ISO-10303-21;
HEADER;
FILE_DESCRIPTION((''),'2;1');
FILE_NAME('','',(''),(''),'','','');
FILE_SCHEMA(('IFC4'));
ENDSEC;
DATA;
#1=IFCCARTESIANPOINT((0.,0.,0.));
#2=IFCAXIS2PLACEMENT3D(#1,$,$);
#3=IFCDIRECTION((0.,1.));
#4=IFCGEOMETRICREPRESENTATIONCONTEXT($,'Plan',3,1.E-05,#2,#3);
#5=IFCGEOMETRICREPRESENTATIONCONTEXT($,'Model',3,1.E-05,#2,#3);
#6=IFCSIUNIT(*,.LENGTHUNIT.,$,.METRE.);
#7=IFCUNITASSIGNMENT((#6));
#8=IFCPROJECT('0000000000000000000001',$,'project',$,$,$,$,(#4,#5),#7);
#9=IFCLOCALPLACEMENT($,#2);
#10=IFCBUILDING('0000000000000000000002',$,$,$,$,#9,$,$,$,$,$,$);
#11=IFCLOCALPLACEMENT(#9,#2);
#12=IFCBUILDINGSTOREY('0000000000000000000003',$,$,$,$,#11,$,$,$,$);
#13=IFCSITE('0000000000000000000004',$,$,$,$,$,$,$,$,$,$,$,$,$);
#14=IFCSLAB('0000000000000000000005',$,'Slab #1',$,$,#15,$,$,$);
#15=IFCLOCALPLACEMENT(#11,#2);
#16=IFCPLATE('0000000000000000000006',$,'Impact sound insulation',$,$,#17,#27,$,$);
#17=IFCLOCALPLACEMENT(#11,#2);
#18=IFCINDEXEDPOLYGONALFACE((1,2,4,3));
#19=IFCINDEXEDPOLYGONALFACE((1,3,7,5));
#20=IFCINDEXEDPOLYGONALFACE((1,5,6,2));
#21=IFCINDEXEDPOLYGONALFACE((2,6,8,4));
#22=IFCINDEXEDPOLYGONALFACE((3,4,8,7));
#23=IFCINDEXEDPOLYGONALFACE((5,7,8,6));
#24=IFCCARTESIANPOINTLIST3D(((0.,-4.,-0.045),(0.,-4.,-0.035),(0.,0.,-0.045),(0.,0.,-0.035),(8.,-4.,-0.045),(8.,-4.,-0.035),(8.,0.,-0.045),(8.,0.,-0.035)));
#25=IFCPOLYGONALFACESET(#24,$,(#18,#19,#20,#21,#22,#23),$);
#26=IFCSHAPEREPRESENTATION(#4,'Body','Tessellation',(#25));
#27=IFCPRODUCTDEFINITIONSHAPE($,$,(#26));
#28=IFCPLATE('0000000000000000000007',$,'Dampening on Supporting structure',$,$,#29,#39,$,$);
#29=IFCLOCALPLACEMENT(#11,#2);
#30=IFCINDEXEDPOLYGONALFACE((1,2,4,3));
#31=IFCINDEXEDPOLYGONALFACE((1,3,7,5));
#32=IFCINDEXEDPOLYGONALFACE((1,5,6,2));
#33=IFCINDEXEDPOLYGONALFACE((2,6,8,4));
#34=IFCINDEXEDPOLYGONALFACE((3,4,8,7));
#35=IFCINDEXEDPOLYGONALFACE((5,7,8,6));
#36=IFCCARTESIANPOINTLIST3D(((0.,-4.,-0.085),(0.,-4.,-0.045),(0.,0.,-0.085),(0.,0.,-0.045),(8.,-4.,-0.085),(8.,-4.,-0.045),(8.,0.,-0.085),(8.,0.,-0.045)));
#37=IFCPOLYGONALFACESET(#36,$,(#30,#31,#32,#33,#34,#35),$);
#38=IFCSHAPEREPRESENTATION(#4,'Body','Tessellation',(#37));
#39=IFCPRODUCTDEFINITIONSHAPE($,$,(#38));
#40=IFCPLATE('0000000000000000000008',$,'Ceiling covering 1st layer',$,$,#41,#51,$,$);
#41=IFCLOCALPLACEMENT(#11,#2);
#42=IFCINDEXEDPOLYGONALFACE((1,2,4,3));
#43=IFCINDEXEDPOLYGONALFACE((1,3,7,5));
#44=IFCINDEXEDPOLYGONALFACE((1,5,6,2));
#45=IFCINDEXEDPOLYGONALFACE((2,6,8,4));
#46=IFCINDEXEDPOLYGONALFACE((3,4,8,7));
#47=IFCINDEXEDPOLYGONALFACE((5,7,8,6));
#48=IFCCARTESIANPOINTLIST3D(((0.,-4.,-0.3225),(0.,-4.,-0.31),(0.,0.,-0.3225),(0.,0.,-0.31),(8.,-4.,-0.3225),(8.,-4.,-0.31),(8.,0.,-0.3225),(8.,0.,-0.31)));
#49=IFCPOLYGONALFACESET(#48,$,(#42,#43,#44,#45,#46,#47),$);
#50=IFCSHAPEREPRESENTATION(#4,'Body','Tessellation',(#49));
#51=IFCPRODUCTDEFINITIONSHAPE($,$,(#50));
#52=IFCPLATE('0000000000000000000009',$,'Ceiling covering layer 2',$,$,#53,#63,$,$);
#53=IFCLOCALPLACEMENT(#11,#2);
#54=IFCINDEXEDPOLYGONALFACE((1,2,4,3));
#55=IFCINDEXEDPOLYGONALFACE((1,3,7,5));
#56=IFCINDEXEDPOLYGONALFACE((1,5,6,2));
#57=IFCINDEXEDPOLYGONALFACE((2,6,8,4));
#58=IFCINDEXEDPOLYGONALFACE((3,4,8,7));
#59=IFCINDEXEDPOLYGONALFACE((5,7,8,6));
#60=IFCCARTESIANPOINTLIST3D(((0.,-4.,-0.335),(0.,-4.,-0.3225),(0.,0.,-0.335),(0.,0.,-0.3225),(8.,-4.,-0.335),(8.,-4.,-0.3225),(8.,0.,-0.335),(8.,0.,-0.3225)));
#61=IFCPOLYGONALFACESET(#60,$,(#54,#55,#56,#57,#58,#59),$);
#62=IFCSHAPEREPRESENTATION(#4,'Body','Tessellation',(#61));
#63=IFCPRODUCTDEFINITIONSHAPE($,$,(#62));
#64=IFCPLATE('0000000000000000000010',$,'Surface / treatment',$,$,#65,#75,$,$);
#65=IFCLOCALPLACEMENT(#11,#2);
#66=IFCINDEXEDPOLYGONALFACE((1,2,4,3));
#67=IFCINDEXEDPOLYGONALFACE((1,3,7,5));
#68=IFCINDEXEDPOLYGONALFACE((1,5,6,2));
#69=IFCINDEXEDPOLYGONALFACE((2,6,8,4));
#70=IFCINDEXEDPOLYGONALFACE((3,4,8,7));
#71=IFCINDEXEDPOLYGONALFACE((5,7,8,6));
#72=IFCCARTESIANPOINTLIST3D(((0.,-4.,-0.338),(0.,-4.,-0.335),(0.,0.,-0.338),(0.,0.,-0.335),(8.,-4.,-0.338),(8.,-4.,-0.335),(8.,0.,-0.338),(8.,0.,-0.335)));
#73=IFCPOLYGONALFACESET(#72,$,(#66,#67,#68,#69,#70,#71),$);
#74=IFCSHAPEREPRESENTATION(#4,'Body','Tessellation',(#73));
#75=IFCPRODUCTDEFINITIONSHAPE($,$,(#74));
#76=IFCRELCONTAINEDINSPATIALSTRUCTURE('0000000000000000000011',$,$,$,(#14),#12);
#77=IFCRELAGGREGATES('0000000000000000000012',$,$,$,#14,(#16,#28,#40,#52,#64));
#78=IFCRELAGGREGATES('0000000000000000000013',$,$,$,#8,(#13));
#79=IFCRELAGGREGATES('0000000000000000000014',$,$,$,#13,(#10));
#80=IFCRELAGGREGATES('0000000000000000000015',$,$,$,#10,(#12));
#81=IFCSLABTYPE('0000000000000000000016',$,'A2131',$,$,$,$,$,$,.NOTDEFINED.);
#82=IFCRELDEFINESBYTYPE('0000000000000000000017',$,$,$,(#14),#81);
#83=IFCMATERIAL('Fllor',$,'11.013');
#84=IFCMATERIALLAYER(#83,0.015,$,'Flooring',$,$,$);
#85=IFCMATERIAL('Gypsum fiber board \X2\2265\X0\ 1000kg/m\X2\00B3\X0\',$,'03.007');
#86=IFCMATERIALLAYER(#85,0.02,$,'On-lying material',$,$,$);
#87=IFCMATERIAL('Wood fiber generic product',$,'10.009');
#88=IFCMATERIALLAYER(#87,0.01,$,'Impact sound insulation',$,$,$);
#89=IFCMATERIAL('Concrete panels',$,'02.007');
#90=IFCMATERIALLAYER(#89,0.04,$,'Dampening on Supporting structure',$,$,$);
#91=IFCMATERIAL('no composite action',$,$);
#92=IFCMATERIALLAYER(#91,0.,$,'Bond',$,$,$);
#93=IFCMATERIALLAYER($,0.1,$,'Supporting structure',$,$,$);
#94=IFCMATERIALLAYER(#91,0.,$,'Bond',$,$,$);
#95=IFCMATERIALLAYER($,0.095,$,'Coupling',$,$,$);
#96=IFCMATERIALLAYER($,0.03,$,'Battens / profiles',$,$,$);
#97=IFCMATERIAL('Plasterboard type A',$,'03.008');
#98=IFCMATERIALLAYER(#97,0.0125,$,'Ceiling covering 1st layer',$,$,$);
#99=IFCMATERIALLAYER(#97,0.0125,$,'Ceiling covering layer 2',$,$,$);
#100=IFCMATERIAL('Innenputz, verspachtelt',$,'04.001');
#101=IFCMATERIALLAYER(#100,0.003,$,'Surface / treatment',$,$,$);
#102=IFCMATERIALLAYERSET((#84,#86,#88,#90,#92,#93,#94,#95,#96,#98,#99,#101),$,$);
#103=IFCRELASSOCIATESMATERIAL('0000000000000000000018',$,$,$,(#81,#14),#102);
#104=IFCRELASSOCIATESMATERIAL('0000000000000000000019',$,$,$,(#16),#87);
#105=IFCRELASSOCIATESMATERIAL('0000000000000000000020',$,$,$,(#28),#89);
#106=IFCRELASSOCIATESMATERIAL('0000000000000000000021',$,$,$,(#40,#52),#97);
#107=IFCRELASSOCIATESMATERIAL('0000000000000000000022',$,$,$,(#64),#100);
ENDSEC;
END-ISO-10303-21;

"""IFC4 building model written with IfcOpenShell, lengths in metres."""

from ifc_helpers import new_model, si_unit, direction, frame, frame_2d, origin, place, context, project, spatial, rectangle, extrude, material, layer, layer_set, type_object, element, aggregate, save


model = new_model("IFC4")

# Units and contexts
plan_context = context("Plan", 3, precision=1e-05, world=origin(), true_north=direction((0.0, 1.0)))
model_context = context("Model", 3, precision=1e-05, world=origin(), true_north=direction((0.0, 1.0)))
ifc_project = project(units=[si_unit("LENGTHUNIT", "METRE")], contexts=[plan_context, model_context])

# Site, building, storey
site = spatial("IfcSite", under=ifc_project)
building_placement = place(None, origin())
building = spatial("IfcBuilding", under=site, at=building_placement)
storey_placement = place(building_placement, origin())
storey = spatial("IfcBuildingStorey", under=building, at=storey_placement)

# Slab, plates
ifc_material_1 = material(Name="Fllor", Category="11.013")
ifc_layer_1 = layer(ifc_material_1, 0.015, Name="Flooring")
ifc_material_2 = material(Name="Gypsum fiber board ≥ 1000kg/m³", Category="03.007")
ifc_layer_2 = layer(ifc_material_2, 0.02, Name="On-lying material")
ifc_material_3 = material(Name="Wood fiber generic product", Category="10.009")
ifc_layer_3 = layer(ifc_material_3, 0.01, Name="Impact sound insulation")
ifc_material_4 = material(Name="Concrete panels", Category="02.007")
ifc_layer_4 = layer(ifc_material_4, 0.04, Name="Dampening on Supporting structure")
ifc_material_5 = material(Name="no composite action")
ifc_layer_5 = layer(ifc_material_5, 0.0, Name="Bond")
ifc_layer_6 = layer(None, 0.1, Name="Supporting structure")
ifc_layer_7 = layer(ifc_material_5, 0.0, Name="Bond")
ifc_layer_8 = layer(None, 0.095, Name="Coupling")
ifc_layer_9 = layer(None, 0.03, Name="Battens / profiles")
ifc_material_6 = material(Name="Plasterboard type A", Category="03.008")
ifc_layer_10 = layer(ifc_material_6, 0.0125, Name="Ceiling covering 1st layer")
ifc_layer_11 = layer(ifc_material_6, 0.0125, Name="Ceiling covering layer 2")
ifc_material_7 = material(Name="Innenputz, verspachtelt", Category="04.001")
ifc_layer_12 = layer(ifc_material_7, 0.003, Name="Surface / treatment")
ifc_layer_set = layer_set([ifc_layer_1, ifc_layer_2, ifc_layer_3, ifc_layer_4, ifc_layer_5, ifc_layer_6, ifc_layer_7, ifc_layer_8, ifc_layer_9, ifc_layer_10, ifc_layer_11, ifc_layer_12])
slab_type = type_object("IfcSlabType", Name="A2131", PredefinedType="NOTDEFINED", material=ifc_layer_set)
slab_placement = place(None, frame((0.0, 0.0, 0.0), z_axis=(0.0, 0.0, -1.0), x_axis=(1.0, 0.0, 0.0)))
slab = element("IfcSlab", 1, at=slab_placement, inside=storey, type_object=slab_type, material=ifc_layer_set, Name="Slab #1")
plate_1_placement = place(slab_placement, origin())
plate_1 = element("IfcPlate", 2, at=plate_1_placement, material=ifc_material_3, Name="Impact sound insulation", context=plan_context, shape_type="SweptSolid", body=[
    extrude(rectangle(XDim=8.0, YDim=4.0, at=frame_2d((4.0, 2.0), x_axis=(1.0, 0.0))), frame((0.0, 0.0, 0.035), z_axis=(0.0, 0.0, 1.0), x_axis=(1.0, 0.0, 0.0)), (0.0, 0.0, 1.0), 0.01),
])
plate_2_placement = place(slab_placement, origin())
plate_2 = element("IfcPlate", 3, at=plate_2_placement, material=ifc_material_4, Name="Dampening on Supporting structure", context=plan_context, shape_type="SweptSolid", body=[
    extrude(rectangle(XDim=8.0, YDim=4.0, at=frame_2d((4.0, 2.0), x_axis=(1.0, 0.0))), frame((0.0, 0.0, 0.045), z_axis=(0.0, 0.0, 1.0), x_axis=(1.0, 0.0, 0.0)), (0.0, 0.0, 1.0), 0.04),
])
plate_3_placement = place(slab_placement, origin())
plate_3 = element("IfcPlate", 4, at=plate_3_placement, material=ifc_material_6, Name="Ceiling covering 1st layer", context=plan_context, shape_type="SweptSolid", body=[
    extrude(rectangle(XDim=8.0, YDim=4.0, at=frame_2d((4.0, 2.0), x_axis=(1.0, 0.0))), frame((0.0, 0.0, 0.31), z_axis=(0.0, 0.0, 1.0), x_axis=(1.0, 0.0, 0.0)), (0.0, 0.0, 1.0), 0.0125),
])
plate_4_placement = place(slab_placement, origin())
plate_4 = element("IfcPlate", 5, at=plate_4_placement, material=ifc_material_6, Name="Ceiling covering layer 2", context=plan_context, shape_type="SweptSolid", body=[
    extrude(rectangle(XDim=8.0, YDim=4.0, at=frame_2d((4.0, 2.0), x_axis=(1.0, 0.0))), frame((0.0, 0.0, 0.3225), z_axis=(0.0, 0.0, 1.0), x_axis=(1.0, 0.0, 0.0)), (0.0, 0.0, 1.0), 0.0125),
])
plate_5_placement = place(slab_placement, origin())
plate_5 = element("IfcPlate", 6, at=plate_5_placement, material=ifc_material_7, Name="Surface / treatment", context=plan_context, shape_type="SweptSolid", body=[
    extrude(rectangle(XDim=8.0, YDim=4.0, at=frame_2d((4.0, 2.0), x_axis=(1.0, 0.0))), frame((0.0, 0.0, 0.335), z_axis=(0.0, 0.0, 1.0), x_axis=(1.0, 0.0, 0.0)), (0.0, 0.0, 1.0), 0.003),
])
aggregate(slab, [plate_1, plate_2, plate_3, plate_4, plate_5])

save(model, "model.ifc")
